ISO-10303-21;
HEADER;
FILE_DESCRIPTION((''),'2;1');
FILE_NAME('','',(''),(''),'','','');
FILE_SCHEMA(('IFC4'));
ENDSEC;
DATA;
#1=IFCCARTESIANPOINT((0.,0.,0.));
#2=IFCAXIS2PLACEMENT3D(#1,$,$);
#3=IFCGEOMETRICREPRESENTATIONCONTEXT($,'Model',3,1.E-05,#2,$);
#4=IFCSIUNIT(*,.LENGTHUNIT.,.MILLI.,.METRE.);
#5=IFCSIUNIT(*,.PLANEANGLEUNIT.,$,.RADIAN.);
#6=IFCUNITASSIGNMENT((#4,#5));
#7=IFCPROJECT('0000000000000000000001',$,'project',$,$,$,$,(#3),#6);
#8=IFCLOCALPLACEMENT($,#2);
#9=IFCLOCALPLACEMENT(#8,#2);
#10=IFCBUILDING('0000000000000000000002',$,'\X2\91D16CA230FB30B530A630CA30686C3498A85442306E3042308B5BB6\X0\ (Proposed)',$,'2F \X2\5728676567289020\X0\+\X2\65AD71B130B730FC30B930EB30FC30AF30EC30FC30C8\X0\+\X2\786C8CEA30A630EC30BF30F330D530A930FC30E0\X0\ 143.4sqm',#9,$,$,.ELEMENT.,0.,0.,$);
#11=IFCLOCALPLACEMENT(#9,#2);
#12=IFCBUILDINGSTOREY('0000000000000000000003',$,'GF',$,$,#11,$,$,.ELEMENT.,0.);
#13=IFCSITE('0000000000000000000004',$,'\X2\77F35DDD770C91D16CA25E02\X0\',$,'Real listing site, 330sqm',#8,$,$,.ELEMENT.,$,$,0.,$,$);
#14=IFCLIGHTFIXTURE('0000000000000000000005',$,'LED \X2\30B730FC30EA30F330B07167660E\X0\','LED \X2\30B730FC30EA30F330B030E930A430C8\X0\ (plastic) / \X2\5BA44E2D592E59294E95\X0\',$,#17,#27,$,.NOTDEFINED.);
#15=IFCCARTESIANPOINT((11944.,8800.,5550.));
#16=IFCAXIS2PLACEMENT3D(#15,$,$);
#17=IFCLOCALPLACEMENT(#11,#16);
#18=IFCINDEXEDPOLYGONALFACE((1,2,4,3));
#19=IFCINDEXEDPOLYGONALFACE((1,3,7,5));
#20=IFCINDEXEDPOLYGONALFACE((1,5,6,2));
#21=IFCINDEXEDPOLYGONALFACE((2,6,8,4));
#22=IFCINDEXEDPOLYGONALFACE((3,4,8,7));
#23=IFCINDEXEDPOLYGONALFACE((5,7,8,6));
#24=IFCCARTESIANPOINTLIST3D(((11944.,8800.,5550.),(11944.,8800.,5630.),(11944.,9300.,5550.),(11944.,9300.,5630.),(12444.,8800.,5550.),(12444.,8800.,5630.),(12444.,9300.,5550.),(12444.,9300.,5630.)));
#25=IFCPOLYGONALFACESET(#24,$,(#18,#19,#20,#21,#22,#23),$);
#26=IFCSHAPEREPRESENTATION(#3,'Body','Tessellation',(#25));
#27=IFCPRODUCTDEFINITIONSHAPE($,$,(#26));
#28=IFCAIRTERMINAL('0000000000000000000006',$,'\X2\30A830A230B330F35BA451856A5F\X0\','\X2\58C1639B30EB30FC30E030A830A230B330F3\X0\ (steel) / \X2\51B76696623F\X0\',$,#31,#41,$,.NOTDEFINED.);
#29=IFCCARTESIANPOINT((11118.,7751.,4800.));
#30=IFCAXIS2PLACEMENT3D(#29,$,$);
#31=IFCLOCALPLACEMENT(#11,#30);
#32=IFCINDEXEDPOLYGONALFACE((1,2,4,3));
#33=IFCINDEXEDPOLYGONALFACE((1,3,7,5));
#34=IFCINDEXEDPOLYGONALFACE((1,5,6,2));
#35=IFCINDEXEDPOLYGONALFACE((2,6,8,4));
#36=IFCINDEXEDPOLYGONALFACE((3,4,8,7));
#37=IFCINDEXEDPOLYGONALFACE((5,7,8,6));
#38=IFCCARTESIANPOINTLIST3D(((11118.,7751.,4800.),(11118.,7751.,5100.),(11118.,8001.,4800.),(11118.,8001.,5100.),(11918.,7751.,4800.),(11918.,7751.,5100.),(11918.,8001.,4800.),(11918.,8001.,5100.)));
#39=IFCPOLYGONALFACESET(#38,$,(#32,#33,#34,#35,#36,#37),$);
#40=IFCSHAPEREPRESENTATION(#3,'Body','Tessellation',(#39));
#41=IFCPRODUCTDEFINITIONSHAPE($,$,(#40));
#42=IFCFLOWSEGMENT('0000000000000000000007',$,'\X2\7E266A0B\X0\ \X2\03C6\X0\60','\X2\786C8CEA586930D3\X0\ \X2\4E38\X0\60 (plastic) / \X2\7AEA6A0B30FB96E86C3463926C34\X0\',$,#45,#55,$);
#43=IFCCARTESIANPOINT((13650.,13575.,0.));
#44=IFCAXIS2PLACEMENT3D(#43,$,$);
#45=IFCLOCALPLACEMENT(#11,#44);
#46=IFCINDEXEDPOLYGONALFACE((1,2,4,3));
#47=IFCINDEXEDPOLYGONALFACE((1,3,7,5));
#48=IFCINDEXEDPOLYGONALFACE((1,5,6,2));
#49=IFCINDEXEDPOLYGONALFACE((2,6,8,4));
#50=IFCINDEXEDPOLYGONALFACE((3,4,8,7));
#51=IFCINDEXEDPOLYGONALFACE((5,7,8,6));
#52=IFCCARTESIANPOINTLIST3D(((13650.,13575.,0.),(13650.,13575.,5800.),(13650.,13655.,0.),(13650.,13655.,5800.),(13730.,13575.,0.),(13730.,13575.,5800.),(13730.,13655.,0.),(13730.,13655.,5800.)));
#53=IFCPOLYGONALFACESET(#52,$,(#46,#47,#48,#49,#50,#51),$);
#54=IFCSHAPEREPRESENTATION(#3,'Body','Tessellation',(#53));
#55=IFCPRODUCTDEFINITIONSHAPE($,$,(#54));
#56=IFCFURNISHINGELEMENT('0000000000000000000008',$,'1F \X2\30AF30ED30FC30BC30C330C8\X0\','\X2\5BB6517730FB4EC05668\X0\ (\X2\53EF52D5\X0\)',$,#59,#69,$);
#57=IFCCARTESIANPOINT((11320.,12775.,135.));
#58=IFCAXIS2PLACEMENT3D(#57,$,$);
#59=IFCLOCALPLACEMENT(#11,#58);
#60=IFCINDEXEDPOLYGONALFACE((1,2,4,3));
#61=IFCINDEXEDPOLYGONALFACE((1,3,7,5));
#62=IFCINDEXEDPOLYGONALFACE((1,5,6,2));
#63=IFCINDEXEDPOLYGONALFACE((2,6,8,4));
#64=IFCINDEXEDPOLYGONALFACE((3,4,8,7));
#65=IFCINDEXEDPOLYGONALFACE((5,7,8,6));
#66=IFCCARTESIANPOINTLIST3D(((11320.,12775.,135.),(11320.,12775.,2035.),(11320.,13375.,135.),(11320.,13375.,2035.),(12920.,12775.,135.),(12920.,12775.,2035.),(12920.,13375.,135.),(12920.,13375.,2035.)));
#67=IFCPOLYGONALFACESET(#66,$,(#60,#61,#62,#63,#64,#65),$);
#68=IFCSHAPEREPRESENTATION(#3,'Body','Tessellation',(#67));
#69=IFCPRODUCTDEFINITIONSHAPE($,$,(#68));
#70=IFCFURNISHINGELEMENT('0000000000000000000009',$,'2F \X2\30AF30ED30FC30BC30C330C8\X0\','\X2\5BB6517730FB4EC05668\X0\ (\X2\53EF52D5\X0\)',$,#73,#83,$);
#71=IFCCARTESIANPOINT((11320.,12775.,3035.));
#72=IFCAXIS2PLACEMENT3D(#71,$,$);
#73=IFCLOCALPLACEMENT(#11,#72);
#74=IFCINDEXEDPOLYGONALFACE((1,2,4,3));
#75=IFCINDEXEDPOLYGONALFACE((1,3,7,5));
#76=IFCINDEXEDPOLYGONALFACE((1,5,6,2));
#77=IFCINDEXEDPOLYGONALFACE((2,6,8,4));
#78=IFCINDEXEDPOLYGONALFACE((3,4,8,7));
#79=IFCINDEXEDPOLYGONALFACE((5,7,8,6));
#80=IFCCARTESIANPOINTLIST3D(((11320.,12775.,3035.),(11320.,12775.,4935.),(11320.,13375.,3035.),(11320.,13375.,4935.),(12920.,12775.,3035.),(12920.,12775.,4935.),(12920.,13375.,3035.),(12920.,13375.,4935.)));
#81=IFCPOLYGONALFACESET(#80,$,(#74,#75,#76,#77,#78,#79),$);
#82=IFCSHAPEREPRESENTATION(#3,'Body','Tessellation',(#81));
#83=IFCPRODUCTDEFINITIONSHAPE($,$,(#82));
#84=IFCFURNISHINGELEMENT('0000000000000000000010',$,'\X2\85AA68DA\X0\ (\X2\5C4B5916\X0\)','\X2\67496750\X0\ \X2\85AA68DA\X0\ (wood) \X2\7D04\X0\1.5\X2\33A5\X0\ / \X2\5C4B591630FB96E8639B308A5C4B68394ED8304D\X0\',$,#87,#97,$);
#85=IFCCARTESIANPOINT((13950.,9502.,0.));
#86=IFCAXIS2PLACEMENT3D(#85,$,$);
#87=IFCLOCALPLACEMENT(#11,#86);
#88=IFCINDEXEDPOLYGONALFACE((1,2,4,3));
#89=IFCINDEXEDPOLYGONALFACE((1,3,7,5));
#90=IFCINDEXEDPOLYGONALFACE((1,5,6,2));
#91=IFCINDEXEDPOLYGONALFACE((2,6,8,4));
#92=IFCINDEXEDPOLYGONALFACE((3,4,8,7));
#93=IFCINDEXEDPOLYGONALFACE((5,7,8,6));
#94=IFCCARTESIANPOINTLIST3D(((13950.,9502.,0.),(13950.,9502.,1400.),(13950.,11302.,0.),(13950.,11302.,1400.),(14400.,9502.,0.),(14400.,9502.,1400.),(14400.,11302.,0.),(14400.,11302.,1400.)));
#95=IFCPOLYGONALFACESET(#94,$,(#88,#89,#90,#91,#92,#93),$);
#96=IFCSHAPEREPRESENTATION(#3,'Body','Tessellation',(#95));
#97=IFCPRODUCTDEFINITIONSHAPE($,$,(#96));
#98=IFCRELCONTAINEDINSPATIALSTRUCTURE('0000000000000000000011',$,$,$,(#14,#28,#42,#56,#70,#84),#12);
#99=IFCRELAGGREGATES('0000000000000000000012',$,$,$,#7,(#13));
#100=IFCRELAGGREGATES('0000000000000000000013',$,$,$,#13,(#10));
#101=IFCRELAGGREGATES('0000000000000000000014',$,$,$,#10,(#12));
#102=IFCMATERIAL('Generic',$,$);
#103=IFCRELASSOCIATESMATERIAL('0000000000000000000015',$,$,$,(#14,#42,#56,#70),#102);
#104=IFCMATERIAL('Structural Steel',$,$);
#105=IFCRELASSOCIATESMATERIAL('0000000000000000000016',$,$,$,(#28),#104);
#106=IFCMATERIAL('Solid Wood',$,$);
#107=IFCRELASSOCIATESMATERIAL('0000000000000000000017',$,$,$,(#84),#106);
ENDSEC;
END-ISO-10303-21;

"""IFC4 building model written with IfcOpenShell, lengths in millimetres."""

from ifc_helpers import new_model, si_unit, frame, frame_2d, origin, place, context, project, spatial, rectangle, extrude, material, element, save


model = new_model("IFC4")

# Units and contexts
model_context = context("Model", 3, precision=1e-05, world=origin())
ifc_project = project(units=[si_unit("LENGTHUNIT", "METRE", prefix="MILLI"), si_unit("PLANEANGLEUNIT", "RADIAN")], contexts=[model_context])

# Site, building, storey
site_placement = place(None, origin())
site = spatial("IfcSite", under=ifc_project, at=site_placement, Name="石川県金沢市", ObjectType="Real listing site, 330sqm", CompositionType="ELEMENT", RefElevation=0.0)
building_placement = place(site_placement, origin())
building = spatial("IfcBuilding", under=site, at=building_placement, Name="金沢・サウナと水風呂のある家 (Proposed)", ObjectType="2F 在来木造+断熱シースルークレート+硬質ウレタンフォーム 143.4sqm", CompositionType="ELEMENT", ElevationOfRefHeight=0.0, ElevationOfTerrain=0.0)
storey_placement = place(building_placement, origin())
storey = spatial("IfcBuildingStorey", under=building, at=storey_placement, Name="GF", CompositionType="ELEMENT", Elevation=0.0)

# Shared definitions
ifc_material_1 = material(Name="Solid Wood")

# Shared definitions
ifc_material_2 = material(Name="Generic")

# Light fixture
light_fixture_1_placement = place(storey_placement, frame((11944.0, 8800.0, 5550.0)))
element("IfcLightFixture", 1, at=light_fixture_1_placement, inside=storey, material=ifc_material_2, Name="LED シーリング照明", Description="LED シーリングライト (plastic) / 室中央天井", PredefinedType="NOTDEFINED", context=model_context, shape_type="SweptSolid", body=[
    extrude(rectangle(XDim=500.0, YDim=500.0, at=frame_2d((250.0, 250.0))), frame((11944.0, 8800.0, 5550.0)), (0.0, 0.0, 1.0), 80.0),
])

# Air terminal
ifc_material_3 = material(Name="Structural Steel")
air_terminal_placement = place(storey_placement, frame((11118.0, 7751.0, 4800.0)))
element("IfcAirTerminal", 2, at=air_terminal_placement, inside=storey, material=ifc_material_3, Name="エアコン室内機", Description="壁掛ルームエアコン (steel) / 冷暖房", PredefinedType="NOTDEFINED", context=model_context, shape_type="SweptSolid", body=[
    extrude(rectangle(XDim=800.0, YDim=250.0, at=frame_2d((400.0, 125.0))), frame((11118.0, 7751.0, 4800.0)), (0.0, 0.0, 1.0), 300.0),
])

# Flow segment
flow_segment_placement = place(storey_placement, frame((13650.0, 13575.0, 0.0)))
element("IfcFlowSegment", 3, at=flow_segment_placement, inside=storey, material=ifc_material_2, Name="縦樋 φ60", Description="硬質塩ビ 丸60 (plastic) / 竪樋・雨水排水", context=model_context, shape_type="SweptSolid", body=[
    extrude(rectangle(XDim=80.0, YDim=80.0, at=frame_2d((40.0, 40.0))), frame((13650.0, 13575.0, 0.0)), (0.0, 0.0, 1.0), 5800.0),
])

# Furnishing elements
furnishing_1_placement = place(storey_placement, frame((11320.0, 12775.0, 135.0)))
element("IfcFurnishingElement", 4, at=furnishing_1_placement, inside=storey, material=ifc_material_2, Name="1F クローゼット", Description="家具・什器 (可動)", context=model_context, shape_type="SweptSolid", body=[
    extrude(rectangle(XDim=1600.0, YDim=600.0, at=frame_2d((800.0, 300.0))), frame((11320.0, 12775.0, 135.0)), (0.0, 0.0, 1.0), 1900.0),
])
furnishing_2_placement = place(storey_placement, frame((11320.0, 12775.0, 3035.0)))
element("IfcFurnishingElement", 5, at=furnishing_2_placement, inside=storey, material=ifc_material_2, Name="2F クローゼット", Description="家具・什器 (可動)", context=model_context, shape_type="SweptSolid", body=[
    extrude(rectangle(XDim=1600.0, YDim=600.0, at=frame_2d((800.0, 300.0))), frame((11320.0, 12775.0, 3035.0)), (0.0, 0.0, 1.0), 1900.0),
])
furnishing_3_placement = place(storey_placement, frame((13950.0, 9502.0, 0.0)))
element("IfcFurnishingElement", 6, at=furnishing_3_placement, inside=storey, material=ifc_material_1, Name="薪棚 (屋外)", Description="杉材 薪棚 (wood) 約1.5㎥ / 屋外・雨掛り屋根付き", context=model_context, shape_type="SweptSolid", body=[
    extrude(rectangle(XDim=450.0, YDim=1800.0, at=frame_2d((225.0, 900.0))), frame((13950.0, 9502.0, 0.0)), (0.0, 0.0, 1.0), 1400.0),
])

save(model, "model.ifc")
